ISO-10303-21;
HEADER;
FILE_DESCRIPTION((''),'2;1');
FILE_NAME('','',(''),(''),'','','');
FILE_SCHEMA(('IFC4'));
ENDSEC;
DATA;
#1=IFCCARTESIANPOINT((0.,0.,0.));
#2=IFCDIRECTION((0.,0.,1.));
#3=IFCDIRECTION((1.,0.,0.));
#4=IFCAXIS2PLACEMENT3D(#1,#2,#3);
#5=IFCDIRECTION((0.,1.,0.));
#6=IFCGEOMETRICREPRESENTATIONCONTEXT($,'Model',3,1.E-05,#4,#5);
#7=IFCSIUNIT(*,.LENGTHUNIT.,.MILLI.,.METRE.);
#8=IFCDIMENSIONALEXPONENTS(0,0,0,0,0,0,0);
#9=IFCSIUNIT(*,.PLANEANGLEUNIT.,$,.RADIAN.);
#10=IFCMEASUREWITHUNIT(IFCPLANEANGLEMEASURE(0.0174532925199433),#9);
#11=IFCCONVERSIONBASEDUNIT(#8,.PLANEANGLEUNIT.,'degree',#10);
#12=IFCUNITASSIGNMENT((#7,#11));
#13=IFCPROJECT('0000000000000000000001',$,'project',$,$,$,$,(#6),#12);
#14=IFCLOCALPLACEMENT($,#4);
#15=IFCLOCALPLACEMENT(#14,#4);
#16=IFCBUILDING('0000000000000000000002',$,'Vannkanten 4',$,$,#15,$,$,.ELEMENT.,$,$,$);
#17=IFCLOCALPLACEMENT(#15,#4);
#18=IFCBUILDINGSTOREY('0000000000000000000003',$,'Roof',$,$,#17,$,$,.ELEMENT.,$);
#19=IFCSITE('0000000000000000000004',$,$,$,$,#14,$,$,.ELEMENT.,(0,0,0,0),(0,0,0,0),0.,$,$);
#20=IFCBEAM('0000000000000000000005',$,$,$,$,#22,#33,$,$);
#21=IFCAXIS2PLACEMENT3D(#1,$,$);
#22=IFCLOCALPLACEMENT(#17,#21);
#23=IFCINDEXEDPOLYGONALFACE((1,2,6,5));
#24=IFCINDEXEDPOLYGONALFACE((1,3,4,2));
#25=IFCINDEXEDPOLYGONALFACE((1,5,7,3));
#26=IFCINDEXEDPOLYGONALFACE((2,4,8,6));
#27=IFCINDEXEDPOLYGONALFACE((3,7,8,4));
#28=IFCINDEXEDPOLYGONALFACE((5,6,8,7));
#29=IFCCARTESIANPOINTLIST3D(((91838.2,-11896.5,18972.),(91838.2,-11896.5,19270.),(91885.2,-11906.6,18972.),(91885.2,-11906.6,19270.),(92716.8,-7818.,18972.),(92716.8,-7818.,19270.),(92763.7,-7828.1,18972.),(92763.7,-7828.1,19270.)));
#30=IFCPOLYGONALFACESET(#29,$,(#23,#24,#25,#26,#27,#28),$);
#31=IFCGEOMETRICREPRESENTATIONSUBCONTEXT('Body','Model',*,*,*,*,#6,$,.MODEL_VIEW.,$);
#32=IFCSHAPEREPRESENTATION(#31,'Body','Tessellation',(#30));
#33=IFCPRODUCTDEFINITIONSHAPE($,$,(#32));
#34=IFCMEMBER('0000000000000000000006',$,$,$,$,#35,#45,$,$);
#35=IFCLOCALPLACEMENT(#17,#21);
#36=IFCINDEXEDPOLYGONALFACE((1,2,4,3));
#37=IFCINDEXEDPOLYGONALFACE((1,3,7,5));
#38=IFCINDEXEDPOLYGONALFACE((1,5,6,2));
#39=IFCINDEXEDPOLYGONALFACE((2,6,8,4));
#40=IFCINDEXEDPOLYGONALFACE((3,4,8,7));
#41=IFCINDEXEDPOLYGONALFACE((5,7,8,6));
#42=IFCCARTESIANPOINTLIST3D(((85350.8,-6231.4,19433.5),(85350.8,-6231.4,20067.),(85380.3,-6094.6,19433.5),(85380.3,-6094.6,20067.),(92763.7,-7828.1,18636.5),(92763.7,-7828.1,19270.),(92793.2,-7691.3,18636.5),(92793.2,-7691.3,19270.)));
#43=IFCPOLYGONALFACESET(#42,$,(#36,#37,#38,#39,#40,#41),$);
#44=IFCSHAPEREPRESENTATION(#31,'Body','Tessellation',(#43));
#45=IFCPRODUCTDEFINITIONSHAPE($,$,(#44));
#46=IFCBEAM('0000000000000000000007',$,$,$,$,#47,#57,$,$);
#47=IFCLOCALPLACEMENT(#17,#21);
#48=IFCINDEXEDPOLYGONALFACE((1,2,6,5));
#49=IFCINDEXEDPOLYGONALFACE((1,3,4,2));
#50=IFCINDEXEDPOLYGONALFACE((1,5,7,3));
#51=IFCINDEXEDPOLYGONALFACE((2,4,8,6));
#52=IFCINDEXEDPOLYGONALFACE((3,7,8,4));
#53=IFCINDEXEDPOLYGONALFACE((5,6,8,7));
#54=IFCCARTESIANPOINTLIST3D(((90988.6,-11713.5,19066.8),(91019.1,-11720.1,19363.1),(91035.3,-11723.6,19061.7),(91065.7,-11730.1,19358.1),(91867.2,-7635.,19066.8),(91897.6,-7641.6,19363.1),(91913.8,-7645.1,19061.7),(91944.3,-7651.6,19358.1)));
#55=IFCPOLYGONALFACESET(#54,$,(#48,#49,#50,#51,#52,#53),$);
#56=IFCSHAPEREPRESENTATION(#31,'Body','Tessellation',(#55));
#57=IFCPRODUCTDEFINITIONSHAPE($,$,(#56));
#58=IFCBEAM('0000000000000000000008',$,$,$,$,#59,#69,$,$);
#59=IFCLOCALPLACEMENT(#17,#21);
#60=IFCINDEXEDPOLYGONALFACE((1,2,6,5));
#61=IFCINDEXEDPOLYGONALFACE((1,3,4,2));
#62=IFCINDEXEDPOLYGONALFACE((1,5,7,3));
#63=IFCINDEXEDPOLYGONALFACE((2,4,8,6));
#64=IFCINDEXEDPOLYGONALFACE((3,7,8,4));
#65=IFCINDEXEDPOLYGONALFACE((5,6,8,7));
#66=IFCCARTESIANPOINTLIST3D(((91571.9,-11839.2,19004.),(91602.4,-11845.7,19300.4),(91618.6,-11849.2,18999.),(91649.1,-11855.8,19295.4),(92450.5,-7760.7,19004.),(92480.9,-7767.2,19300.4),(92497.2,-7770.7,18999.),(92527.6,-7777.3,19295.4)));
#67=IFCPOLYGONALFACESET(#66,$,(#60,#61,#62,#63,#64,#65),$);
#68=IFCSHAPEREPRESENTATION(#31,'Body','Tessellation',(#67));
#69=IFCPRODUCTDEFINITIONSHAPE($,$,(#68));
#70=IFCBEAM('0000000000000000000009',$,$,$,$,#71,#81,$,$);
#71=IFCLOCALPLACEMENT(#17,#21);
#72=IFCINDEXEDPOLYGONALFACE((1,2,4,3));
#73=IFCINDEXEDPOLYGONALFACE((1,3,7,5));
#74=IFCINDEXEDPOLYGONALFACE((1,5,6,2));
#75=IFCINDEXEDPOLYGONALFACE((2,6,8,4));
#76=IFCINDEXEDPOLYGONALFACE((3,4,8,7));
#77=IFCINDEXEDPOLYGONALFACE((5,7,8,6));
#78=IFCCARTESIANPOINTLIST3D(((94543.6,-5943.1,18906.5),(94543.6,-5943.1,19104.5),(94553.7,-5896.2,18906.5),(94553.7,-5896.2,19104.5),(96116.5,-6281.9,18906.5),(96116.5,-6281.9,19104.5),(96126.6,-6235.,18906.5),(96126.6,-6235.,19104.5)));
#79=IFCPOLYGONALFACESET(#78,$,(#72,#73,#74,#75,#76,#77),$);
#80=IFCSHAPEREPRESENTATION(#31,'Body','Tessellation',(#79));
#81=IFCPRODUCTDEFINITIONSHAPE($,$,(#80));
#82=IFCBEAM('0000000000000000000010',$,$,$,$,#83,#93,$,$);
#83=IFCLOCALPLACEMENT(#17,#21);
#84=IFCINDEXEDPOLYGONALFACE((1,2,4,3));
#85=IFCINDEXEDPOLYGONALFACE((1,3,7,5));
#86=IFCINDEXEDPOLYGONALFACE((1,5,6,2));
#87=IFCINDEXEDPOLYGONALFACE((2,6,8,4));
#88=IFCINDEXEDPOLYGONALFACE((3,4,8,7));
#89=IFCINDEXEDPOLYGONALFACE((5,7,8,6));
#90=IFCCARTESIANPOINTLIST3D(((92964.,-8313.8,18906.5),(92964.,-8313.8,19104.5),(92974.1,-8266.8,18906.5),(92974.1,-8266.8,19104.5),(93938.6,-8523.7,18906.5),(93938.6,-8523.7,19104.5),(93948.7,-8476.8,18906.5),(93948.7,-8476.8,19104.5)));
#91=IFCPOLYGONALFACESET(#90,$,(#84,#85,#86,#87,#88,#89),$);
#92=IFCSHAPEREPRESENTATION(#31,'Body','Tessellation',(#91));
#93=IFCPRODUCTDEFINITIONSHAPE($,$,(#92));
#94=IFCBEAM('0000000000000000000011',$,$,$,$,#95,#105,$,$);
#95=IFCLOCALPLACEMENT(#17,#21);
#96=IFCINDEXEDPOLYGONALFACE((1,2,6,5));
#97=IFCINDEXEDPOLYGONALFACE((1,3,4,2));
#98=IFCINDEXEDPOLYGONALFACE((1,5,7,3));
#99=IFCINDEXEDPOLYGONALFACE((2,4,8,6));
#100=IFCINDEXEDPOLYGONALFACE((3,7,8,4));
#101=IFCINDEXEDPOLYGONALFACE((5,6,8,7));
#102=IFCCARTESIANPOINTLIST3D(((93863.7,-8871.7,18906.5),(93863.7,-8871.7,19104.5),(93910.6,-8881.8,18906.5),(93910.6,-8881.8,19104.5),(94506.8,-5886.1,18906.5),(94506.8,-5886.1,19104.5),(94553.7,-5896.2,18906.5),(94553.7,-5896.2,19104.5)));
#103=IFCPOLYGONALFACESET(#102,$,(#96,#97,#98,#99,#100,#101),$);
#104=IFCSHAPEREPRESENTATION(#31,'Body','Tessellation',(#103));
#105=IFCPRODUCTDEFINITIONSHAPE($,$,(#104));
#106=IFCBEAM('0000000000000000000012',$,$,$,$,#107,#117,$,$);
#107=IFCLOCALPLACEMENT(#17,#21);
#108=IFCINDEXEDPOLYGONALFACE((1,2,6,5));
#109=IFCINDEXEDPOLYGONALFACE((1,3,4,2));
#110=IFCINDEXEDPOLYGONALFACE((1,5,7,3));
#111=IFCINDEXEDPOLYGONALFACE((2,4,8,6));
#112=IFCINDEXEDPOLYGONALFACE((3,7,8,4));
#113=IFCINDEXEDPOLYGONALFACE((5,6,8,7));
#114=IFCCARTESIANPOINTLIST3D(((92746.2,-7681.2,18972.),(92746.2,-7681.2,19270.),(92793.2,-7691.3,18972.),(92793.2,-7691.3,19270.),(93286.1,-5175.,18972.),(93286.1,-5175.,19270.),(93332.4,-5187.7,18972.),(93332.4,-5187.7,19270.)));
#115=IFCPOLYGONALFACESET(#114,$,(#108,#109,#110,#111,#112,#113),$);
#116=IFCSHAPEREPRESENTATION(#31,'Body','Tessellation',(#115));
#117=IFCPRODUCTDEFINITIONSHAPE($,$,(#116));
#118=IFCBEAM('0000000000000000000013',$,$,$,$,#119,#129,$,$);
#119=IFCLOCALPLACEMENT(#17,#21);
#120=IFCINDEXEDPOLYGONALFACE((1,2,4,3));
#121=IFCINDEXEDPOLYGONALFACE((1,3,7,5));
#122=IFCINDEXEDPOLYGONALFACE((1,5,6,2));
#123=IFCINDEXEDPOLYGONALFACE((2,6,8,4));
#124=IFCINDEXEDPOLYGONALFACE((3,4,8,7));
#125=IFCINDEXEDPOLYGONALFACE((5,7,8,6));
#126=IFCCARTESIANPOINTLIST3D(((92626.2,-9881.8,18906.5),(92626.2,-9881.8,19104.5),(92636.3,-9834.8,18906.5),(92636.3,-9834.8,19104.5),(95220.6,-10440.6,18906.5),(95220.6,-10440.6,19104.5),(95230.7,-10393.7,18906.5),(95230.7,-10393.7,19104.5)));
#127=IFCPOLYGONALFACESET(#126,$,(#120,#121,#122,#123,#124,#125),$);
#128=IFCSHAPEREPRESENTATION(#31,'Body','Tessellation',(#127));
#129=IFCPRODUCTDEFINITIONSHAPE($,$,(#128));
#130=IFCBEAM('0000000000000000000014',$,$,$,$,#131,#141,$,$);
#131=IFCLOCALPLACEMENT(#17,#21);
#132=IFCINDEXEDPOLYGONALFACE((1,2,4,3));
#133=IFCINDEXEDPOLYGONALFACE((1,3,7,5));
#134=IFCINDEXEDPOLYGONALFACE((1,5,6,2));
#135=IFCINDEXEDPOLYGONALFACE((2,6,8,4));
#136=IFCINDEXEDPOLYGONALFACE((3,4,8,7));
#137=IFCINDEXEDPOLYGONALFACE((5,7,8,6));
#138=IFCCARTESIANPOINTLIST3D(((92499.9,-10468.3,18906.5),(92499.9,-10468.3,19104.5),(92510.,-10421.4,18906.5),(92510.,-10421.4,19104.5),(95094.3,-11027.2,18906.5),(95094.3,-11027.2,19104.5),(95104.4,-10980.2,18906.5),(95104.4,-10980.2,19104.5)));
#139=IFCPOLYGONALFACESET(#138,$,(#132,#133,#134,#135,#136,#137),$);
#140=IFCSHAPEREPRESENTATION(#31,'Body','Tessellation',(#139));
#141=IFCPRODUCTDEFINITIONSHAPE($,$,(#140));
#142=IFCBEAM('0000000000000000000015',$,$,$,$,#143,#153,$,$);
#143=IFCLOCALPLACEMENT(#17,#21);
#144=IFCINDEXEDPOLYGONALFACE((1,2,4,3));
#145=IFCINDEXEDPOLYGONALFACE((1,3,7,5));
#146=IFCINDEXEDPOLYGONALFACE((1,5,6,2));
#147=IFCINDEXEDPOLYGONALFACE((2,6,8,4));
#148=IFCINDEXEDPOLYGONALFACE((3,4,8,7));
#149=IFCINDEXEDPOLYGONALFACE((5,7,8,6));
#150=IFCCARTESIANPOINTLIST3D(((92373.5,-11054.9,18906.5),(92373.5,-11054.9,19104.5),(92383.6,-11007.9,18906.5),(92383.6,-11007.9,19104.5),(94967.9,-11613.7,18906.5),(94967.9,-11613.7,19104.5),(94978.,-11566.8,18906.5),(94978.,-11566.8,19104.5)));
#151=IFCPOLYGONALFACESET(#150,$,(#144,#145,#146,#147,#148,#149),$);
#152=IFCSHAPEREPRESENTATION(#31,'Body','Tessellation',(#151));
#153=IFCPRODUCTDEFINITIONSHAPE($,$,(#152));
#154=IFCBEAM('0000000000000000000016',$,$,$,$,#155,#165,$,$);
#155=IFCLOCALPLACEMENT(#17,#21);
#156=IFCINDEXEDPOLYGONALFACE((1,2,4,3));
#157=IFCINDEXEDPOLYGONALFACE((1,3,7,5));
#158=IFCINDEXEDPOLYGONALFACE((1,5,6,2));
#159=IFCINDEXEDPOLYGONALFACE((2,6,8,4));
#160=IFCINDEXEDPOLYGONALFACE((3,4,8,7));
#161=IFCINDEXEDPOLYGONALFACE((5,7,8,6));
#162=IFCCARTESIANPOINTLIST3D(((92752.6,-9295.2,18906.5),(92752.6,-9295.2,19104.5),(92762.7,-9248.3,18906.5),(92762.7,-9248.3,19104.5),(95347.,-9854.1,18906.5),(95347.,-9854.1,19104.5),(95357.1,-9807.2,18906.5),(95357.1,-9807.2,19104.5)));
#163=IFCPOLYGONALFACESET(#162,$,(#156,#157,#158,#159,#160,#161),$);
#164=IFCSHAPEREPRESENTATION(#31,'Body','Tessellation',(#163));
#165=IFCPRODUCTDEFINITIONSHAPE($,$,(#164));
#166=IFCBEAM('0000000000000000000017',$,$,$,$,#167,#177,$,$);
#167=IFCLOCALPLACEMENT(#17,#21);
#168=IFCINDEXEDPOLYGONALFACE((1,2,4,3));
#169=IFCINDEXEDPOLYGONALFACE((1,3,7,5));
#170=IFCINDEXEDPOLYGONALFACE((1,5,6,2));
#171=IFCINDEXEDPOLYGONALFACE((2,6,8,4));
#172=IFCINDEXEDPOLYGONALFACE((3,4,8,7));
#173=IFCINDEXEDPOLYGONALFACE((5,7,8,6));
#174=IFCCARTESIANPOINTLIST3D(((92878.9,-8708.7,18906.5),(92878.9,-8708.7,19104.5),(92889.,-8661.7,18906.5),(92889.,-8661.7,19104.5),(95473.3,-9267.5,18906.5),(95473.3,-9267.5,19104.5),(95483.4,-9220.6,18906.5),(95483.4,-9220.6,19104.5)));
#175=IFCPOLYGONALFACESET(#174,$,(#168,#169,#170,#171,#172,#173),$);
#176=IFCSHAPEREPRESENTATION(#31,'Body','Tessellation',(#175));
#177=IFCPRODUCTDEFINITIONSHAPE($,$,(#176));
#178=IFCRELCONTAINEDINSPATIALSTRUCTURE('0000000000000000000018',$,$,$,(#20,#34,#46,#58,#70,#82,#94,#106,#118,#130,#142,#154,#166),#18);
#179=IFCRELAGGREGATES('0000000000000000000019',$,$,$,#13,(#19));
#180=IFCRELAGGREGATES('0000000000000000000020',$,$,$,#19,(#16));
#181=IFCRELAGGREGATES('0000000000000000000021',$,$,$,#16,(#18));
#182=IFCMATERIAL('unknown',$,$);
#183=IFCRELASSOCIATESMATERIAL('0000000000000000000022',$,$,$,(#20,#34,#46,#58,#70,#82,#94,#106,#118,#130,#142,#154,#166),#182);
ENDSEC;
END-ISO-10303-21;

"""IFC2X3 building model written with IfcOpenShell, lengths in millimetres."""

from ifc_helpers import new_model, entity, si_unit, converted_unit, direction, frame, origin_with_axes, place, context, subcontext, project, spatial, polyline, segment, composite_curve, outline, extrude, clip, halfspace, material, element, save


model = new_model("IFC2X3")

# Units and contexts
model_context = context("Model", 3, precision=1e-05, world=origin_with_axes(), true_north=direction((0.0, 1.0, 0.0)))
body_context = subcontext(model_context, "Body", "Model", "MODEL_VIEW")
ifc_project = project(units=[si_unit("LENGTHUNIT", "METRE", prefix="MILLI"), converted_unit("PLANEANGLEUNIT", "degree", entity("IfcPlaneAngleMeasure", 0.0174532925199433), si_unit("PLANEANGLEUNIT", "RADIAN"), dimensions=[0, 0, 0, 0, 0, 0, 0])], contexts=[model_context])

# Site, building, storey
site_placement = place(None, origin_with_axes())
site = spatial("IfcSite", under=ifc_project, at=site_placement, CompositionType="ELEMENT", RefLatitude=(0, 0, 0, 0), RefLongitude=(0, 0, 0, 0), RefElevation=0.0)
building_placement = place(site_placement, origin_with_axes())
building = spatial("IfcBuilding", under=site, at=building_placement, Name="Vannkanten 4", CompositionType="ELEMENT")
storey_placement = place(building_placement, origin_with_axes())
storey = spatial("IfcBuildingStorey", under=building, at=storey_placement, Name="Roof", CompositionType="ELEMENT")

# Shared definitions
ifc_material = material(Name="unknown")

# Beam
beam_1_placement = place(storey_placement, frame((92740.2, -7823.1, 19121.0), z_axis=(-0.210576, -0.977578, -0.000001), x_axis=(0.977578, -0.210576, 0.0)))
element("IfcBeam", 1, at=beam_1_placement, inside=storey, material=ifc_material, context=body_context, shape_type="SweptSolid", body=[
    extrude(outline(composite_curve([segment(polyline([(-24.0, -149.0), (-24.0, 149.0), (24.0, 149.0), (24.0, -149.0), (-24.0, -149.0)]), True, "CONTINUOUS")], self_intersect=False)), frame((0.0, 0.0, 0.0), z_axis=(0.0, 0.0, 1.0), x_axis=(1.0, 0.0, 0.0)), (0.0, 0.0, 1.0), 4172.0),
])

# Member
member_1_placement = place(storey_placement, frame((92778.4, -7759.7, 18953.3), z_axis=(-0.972224, 0.209415, 0.104528), x_axis=(-0.210568, -0.977579, 0.0)))
element("IfcMember", 2, at=member_1_placement, inside=storey, material=ifc_material, context=body_context, shape_type="Clipping", body=[
    clip(clip(extrude(outline(composite_curve([segment(polyline([(-70.0, 315.0), (-70.0, -315.0), (70.0, -315.0), (70.0, 315.0), (-70.0, 315.0)]), True, "CONTINUOUS")], self_intersect=False)), frame((0.0, 0.0, -3878.6), z_axis=(0.0, 0.0, 1.0), x_axis=(1.0, 0.0, 0.0)), (0.0, 0.0, 1.0), 15381.9), halfspace(frame((-70.0, 315.0, 33.1), z_axis=(-0.000008, -0.104528, 0.994522), x_axis=(0.0, 0.994522, 0.104528)), True)), halfspace(frame((70.0, 315.0, 7657.8), z_axis=(0.000014, 0.104528, -0.994522), x_axis=(0.0, -0.994522, -0.104528)), True)),
])

# Beams
beam_2_placement = place(storey_placement, frame((91027.2, -11721.8, 19212.4), z_axis=(0.210582, 0.977576, 0.0), x_axis=(-0.972221, 0.209428, 0.104528)))
element("IfcBeam", 3, at=beam_2_placement, inside=storey, material=ifc_material, context=body_context, shape_type="SweptSolid", body=[
    extrude(outline(composite_curve([segment(polyline([(-24.0, -149.0), (-24.0, 149.0), (24.0, 149.0), (24.0, -149.0), (-24.0, -149.0)]), True, "CONTINUOUS")], self_intersect=False)), frame((0.0, 0.0, 0.0), z_axis=(0.0, 0.0, 1.0), x_axis=(1.0, 0.0, 0.0)), (0.0, 0.0, 1.0), 4172.0),
])
beam_3_placement = place(storey_placement, frame((91610.5, -11847.5, 19149.7), z_axis=(0.210582, 0.977576, 0.0), x_axis=(-0.972221, 0.209428, 0.104528)))
element("IfcBeam", 4, at=beam_3_placement, inside=storey, material=ifc_material, context=body_context, shape_type="SweptSolid", body=[
    extrude(outline(composite_curve([segment(polyline([(-24.0, -149.0), (-24.0, 149.0), (24.0, 149.0), (24.0, -149.0), (-24.0, -149.0)]), True, "CONTINUOUS")], self_intersect=False)), frame((0.0, 0.0, 0.0), z_axis=(0.0, 0.0, 1.0), x_axis=(1.0, 0.0, 0.0)), (0.0, 0.0, 1.0), 4172.0),
])
beam_4_placement = place(storey_placement, frame((96121.5, -6258.4, 19005.5), z_axis=(-0.977576, 0.210582, 0.0), x_axis=(-0.210582, -0.977576, 0.0)))
element("IfcBeam", 5, at=beam_4_placement, inside=storey, material=ifc_material, context=body_context, shape_type="SweptSolid", body=[
    extrude(outline(composite_curve([segment(polyline([(-24.0, -99.0), (-24.0, 99.0), (24.0, 99.0), (24.0, -99.0), (-24.0, -99.0)]), True, "CONTINUOUS")], self_intersect=False)), origin_with_axes(), (0.0, 0.0, 1.0), 1608.9),
])
beam_5_placement = place(storey_placement, frame((93943.7, -8500.2, 19005.5), z_axis=(-0.977576, 0.210582, 0.0), x_axis=(-0.210582, -0.977576, 0.0)))
element("IfcBeam", 6, at=beam_5_placement, inside=storey, material=ifc_material, context=body_context, shape_type="SweptSolid", body=[
    extrude(outline(composite_curve([segment(polyline([(-24.0, -99.0), (-24.0, 99.0), (24.0, 99.0), (24.0, -99.0), (-24.0, -99.0)]), True, "CONTINUOUS")], self_intersect=False)), frame((0.0, 0.0, 0.0), z_axis=(0.0, 0.0, 1.0), x_axis=(1.0, 0.0, 0.0)), (0.0, 0.0, 1.0), 997.0),
])
beam_6_placement = place(storey_placement, frame((94530.3, -5891.1, 19005.5), z_axis=(-0.210582, -0.977576, 0.0), x_axis=(0.977576, -0.210582, 0.0)))
element("IfcBeam", 7, at=beam_6_placement, inside=storey, material=ifc_material, context=body_context, shape_type="SweptSolid", body=[
    extrude(outline(composite_curve([segment(polyline([(-24.0, -99.0), (-24.0, 99.0), (24.0, 99.0), (24.0, -99.0), (-24.0, -99.0)]), True, "CONTINUOUS")], self_intersect=False)), frame((0.0, 0.0, 0.0), z_axis=(0.0, 0.0, 1.0), x_axis=(1.0, 0.0, 0.0)), (0.0, 0.0, 1.0), 3054.1),
])
beam_7_placement = place(storey_placement, frame((93309.3, -5181.3, 19121.0), z_axis=(-0.210576, -0.977578, -0.000001), x_axis=(0.977578, -0.210576, 0.0)))
element("IfcBeam", 8, at=beam_7_placement, inside=storey, material=ifc_material, context=body_context, shape_type="Clipping", body=[
    clip(extrude(outline(composite_curve([segment(polyline([(-24.0, -149.0), (-24.0, 149.0), (24.0, 149.0), (24.0, -149.0), (-24.0, -149.0)]), True, "CONTINUOUS")], self_intersect=False)), frame((0.0, 0.0, -1283.2), z_axis=(0.0, 0.0, 1.0), x_axis=(1.0, 0.0, 0.0)), (0.0, 0.0, 1.0), 3845.5), halfspace(frame((-24.0, 149.0, -1.3), z_axis=(-0.055805, 0.000001, 0.998442), x_axis=(0.998442, 0.0, 0.055805)), True)),
])
beam_8_placement = place(storey_placement, frame((95225.7, -10417.2, 19005.5), z_axis=(-0.977576, 0.210582, 0.0), x_axis=(-0.210582, -0.977576, 0.0)))
element("IfcBeam", 9, at=beam_8_placement, inside=storey, material=ifc_material, context=body_context, shape_type="SweptSolid", body=[
    extrude(outline(composite_curve([segment(polyline([(-24.0, -99.0), (-24.0, 99.0), (24.0, 99.0), (24.0, -99.0), (-24.0, -99.0)]), True, "CONTINUOUS")], self_intersect=False)), frame((0.0, 0.0, 0.0), z_axis=(0.0, 0.0, 1.0), x_axis=(1.0, 0.0, 0.0)), (0.0, 0.0, 1.0), 2653.9),
])
beam_9_placement = place(storey_placement, frame((95099.3, -11003.7, 19005.5), z_axis=(-0.977576, 0.210582, 0.0), x_axis=(-0.210582, -0.977576, 0.0)))
element("IfcBeam", 10, at=beam_9_placement, inside=storey, material=ifc_material, context=body_context, shape_type="SweptSolid", body=[
    extrude(outline(composite_curve([segment(polyline([(-24.0, -99.0), (-24.0, 99.0), (24.0, 99.0), (24.0, -99.0), (-24.0, -99.0)]), True, "CONTINUOUS")], self_intersect=False)), frame((0.0, 0.0, 0.0), z_axis=(0.0, 0.0, 1.0), x_axis=(1.0, 0.0, 0.0)), (0.0, 0.0, 1.0), 2653.9),
])
beam_10_placement = place(storey_placement, frame((94973.0, -11590.3, 19005.5), z_axis=(-0.977576, 0.210582, 0.0), x_axis=(-0.210582, -0.977576, 0.0)))
element("IfcBeam", 11, at=beam_10_placement, inside=storey, material=ifc_material, context=body_context, shape_type="SweptSolid", body=[
    extrude(outline(composite_curve([segment(polyline([(-24.0, -99.0), (-24.0, 99.0), (24.0, 99.0), (24.0, -99.0), (-24.0, -99.0)]), True, "CONTINUOUS")], self_intersect=False)), frame((0.0, 0.0, 0.0), z_axis=(0.0, 0.0, 1.0), x_axis=(1.0, 0.0, 0.0)), (0.0, 0.0, 1.0), 2653.9),
])
beam_11_placement = place(storey_placement, frame((95352.0, -9830.6, 19005.5), z_axis=(-0.977576, 0.210582, 0.0), x_axis=(-0.210582, -0.977576, 0.0)))
element("IfcBeam", 12, at=beam_11_placement, inside=storey, material=ifc_material, context=body_context, shape_type="SweptSolid", body=[
    extrude(outline(composite_curve([segment(polyline([(-24.0, -99.0), (-24.0, 99.0), (24.0, 99.0), (24.0, -99.0), (-24.0, -99.0)]), True, "CONTINUOUS")], self_intersect=False)), frame((0.0, 0.0, 0.0), z_axis=(0.0, 0.0, 1.0), x_axis=(1.0, 0.0, 0.0)), (0.0, 0.0, 1.0), 2653.9),
])
beam_12_placement = place(storey_placement, frame((95478.4, -9244.1, 19005.5), z_axis=(-0.977576, 0.210582, 0.0), x_axis=(-0.210582, -0.977576, 0.0)))
element("IfcBeam", 13, at=beam_12_placement, inside=storey, material=ifc_material, context=body_context, shape_type="SweptSolid", body=[
    extrude(outline(composite_curve([segment(polyline([(-24.0, -99.0), (-24.0, 99.0), (24.0, 99.0), (24.0, -99.0), (-24.0, -99.0)]), True, "CONTINUOUS")], self_intersect=False)), frame((0.0, 0.0, 0.0), z_axis=(0.0, 0.0, 1.0), x_axis=(1.0, 0.0, 0.0)), (0.0, 0.0, 1.0), 2653.9),
])

save(model, "model.ifc")
